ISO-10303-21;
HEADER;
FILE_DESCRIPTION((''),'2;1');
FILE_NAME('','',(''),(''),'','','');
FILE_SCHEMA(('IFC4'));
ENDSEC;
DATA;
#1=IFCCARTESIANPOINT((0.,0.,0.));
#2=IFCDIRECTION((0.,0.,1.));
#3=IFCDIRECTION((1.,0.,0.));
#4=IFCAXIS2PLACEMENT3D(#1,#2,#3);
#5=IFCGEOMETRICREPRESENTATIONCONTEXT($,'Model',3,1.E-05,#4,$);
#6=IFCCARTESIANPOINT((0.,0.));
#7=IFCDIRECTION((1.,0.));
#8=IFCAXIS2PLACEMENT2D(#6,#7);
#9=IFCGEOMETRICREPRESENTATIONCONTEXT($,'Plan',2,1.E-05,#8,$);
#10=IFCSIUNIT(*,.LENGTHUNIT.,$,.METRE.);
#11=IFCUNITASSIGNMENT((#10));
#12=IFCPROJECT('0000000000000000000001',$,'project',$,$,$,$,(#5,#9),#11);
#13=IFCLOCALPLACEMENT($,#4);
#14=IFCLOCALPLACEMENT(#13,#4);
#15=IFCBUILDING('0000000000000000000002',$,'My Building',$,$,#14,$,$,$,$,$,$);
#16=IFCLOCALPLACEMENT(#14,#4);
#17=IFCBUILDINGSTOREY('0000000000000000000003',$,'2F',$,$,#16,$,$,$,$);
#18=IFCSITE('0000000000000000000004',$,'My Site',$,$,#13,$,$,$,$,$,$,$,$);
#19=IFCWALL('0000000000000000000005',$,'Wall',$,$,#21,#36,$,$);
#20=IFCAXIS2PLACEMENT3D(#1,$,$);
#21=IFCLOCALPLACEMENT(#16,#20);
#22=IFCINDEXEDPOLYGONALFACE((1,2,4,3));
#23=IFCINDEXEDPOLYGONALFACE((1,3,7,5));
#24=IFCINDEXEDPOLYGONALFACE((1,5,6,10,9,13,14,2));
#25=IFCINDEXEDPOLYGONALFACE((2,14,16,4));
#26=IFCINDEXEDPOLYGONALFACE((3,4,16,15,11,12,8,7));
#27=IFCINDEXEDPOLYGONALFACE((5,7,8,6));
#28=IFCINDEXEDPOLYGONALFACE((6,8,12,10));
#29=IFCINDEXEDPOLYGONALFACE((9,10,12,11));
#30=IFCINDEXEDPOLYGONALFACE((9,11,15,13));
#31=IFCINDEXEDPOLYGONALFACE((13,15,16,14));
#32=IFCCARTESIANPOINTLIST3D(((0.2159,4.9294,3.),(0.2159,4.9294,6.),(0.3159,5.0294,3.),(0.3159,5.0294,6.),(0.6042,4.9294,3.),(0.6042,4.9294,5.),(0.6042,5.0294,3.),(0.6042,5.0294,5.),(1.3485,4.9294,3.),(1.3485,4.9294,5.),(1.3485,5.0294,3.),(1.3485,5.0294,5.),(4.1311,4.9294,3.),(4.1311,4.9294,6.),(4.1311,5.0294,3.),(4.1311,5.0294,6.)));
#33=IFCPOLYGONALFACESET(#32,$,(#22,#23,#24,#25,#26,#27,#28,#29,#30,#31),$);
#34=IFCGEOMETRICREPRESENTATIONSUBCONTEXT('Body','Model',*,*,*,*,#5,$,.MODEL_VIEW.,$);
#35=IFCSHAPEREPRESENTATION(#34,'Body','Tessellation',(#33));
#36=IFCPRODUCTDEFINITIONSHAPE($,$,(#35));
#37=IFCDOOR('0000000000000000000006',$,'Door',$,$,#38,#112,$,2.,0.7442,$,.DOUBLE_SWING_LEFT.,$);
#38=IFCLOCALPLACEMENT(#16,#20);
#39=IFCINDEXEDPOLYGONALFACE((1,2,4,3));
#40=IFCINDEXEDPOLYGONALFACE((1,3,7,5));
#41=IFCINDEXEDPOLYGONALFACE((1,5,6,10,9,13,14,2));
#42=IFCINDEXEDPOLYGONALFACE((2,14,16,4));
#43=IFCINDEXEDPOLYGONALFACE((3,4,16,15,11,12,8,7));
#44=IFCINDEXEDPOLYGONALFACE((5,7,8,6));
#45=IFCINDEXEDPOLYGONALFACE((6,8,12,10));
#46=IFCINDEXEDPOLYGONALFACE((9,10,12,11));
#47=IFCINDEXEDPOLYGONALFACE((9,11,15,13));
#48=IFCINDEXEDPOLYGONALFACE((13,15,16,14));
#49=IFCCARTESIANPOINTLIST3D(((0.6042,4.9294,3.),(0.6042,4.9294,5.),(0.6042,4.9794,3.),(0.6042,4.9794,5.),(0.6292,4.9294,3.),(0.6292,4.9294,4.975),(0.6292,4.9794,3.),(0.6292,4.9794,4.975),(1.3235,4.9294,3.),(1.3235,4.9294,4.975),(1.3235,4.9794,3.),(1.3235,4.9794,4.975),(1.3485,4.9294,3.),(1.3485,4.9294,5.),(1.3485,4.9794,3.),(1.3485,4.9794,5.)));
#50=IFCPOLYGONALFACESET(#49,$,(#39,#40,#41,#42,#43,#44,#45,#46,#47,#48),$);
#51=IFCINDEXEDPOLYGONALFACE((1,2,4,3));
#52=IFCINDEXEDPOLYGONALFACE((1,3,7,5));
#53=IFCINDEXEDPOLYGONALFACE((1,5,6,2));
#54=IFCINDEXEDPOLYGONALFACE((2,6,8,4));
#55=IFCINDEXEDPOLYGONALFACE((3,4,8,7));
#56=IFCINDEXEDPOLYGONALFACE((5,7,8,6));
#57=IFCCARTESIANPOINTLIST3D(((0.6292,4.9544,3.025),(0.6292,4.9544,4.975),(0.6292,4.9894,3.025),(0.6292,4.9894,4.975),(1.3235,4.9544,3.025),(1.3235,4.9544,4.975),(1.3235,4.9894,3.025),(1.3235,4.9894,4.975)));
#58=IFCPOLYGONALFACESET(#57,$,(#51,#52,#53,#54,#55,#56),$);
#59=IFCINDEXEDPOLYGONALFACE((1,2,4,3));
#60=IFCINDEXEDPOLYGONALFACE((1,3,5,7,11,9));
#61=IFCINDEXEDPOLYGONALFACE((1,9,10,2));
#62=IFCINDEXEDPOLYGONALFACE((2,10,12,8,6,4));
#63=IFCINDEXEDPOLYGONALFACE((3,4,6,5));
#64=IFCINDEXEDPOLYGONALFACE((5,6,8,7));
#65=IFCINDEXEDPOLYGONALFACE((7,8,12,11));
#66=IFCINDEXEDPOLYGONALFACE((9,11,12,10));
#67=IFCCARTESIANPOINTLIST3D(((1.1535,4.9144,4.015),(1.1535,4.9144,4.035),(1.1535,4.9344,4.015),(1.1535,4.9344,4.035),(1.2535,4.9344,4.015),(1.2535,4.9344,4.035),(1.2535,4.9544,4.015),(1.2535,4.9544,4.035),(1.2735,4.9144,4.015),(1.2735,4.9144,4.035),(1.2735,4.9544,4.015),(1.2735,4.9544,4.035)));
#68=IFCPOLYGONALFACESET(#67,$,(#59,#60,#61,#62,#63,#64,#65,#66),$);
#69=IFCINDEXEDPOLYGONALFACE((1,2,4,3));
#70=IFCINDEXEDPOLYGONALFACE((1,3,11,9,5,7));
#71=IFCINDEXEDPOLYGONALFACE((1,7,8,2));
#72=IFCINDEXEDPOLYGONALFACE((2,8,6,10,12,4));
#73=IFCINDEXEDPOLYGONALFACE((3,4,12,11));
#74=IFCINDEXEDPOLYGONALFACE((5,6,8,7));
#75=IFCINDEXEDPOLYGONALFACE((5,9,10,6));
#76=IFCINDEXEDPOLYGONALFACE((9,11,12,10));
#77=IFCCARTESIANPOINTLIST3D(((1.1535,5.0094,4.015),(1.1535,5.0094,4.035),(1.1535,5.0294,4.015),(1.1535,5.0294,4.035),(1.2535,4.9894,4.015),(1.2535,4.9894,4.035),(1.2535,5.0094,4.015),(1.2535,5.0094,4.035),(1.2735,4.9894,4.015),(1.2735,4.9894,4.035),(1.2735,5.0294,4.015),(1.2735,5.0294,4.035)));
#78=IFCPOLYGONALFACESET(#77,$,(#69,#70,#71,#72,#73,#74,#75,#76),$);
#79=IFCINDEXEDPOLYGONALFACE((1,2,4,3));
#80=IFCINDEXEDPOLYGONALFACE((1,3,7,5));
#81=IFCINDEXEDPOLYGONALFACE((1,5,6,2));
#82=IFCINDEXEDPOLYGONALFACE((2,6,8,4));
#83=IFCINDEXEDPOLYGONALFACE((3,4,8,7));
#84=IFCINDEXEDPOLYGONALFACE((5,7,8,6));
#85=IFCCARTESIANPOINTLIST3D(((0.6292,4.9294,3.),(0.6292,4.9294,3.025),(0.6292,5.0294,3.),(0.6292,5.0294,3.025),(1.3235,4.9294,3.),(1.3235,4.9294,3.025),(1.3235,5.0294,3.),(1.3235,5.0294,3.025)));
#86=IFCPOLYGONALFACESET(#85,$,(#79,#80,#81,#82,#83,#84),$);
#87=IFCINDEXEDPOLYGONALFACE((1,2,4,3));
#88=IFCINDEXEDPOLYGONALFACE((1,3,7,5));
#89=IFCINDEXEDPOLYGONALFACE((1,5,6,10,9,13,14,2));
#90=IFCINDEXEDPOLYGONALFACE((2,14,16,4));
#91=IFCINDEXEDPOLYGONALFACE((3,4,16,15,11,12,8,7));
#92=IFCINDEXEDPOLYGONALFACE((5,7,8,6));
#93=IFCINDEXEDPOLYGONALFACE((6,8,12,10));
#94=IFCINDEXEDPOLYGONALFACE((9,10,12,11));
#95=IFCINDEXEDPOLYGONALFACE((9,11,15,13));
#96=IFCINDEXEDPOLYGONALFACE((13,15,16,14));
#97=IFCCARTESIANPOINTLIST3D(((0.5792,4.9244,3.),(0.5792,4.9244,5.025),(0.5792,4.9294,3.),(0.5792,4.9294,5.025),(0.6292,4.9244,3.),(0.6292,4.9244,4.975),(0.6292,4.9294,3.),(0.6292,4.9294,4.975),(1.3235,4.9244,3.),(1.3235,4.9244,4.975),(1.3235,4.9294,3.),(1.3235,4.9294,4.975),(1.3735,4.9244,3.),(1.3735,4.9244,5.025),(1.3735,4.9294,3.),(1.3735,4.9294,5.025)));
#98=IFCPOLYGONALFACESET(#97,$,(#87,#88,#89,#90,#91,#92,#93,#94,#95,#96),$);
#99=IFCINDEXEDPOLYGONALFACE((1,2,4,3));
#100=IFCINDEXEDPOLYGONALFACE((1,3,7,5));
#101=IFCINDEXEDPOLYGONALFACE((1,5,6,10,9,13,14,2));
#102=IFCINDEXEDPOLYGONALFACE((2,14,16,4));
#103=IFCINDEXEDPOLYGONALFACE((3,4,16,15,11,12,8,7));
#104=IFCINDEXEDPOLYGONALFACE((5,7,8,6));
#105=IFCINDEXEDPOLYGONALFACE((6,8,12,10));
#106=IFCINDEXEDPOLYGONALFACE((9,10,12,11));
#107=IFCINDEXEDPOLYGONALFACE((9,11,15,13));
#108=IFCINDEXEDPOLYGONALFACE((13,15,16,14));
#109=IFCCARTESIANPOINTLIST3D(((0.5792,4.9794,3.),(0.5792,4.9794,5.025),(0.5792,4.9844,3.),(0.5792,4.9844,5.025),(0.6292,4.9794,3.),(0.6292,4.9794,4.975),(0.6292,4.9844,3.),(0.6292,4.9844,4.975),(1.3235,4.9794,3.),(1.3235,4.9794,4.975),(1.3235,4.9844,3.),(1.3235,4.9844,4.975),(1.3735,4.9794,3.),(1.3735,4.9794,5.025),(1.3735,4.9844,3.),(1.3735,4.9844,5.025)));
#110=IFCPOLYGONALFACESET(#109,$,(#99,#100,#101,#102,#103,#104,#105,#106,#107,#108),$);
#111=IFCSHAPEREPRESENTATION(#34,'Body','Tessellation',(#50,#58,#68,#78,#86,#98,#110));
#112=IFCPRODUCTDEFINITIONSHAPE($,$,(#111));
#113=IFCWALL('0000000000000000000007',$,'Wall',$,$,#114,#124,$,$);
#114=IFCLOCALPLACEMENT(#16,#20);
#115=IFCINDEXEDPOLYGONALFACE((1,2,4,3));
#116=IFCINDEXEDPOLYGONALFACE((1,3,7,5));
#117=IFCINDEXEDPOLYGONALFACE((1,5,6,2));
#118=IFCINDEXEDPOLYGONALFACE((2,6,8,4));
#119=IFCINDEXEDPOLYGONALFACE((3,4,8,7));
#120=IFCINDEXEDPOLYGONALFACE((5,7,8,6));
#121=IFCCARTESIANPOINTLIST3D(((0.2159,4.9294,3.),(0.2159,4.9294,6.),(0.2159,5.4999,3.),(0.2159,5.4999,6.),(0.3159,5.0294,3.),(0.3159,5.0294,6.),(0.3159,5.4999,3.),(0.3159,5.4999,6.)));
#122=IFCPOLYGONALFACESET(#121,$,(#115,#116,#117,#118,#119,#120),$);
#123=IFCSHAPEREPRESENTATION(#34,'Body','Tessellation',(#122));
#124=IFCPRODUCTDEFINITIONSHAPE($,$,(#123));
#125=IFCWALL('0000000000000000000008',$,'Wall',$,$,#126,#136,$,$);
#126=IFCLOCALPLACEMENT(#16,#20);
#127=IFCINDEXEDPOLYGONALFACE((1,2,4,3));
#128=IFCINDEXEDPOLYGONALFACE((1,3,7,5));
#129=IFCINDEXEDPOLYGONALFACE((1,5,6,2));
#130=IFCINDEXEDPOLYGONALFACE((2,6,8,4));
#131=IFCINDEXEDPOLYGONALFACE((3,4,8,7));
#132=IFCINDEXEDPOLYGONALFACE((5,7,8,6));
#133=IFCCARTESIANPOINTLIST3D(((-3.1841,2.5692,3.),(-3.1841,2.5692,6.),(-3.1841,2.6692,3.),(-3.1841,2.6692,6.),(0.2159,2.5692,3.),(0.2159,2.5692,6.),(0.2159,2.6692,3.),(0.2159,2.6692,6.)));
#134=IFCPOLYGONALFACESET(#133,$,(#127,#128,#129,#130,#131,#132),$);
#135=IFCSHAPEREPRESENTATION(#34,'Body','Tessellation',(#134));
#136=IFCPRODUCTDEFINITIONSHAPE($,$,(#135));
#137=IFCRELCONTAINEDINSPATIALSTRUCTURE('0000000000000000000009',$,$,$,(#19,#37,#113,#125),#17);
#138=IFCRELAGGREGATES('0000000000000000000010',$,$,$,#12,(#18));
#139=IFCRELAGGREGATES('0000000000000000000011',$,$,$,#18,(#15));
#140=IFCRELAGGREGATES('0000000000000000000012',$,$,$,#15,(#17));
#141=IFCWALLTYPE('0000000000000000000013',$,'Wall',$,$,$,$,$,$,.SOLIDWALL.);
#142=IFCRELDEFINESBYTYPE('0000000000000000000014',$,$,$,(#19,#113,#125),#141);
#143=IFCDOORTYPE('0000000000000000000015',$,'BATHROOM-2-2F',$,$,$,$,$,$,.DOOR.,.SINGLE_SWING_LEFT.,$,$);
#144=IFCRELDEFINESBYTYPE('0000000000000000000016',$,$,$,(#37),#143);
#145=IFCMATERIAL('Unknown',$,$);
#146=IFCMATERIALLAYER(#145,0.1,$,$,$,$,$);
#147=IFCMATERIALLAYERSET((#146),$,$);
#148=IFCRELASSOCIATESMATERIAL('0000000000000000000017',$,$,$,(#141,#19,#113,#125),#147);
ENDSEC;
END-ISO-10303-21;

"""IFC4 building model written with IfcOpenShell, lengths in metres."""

from ifc_helpers import new_model, entity, si_unit, frame, origin_with_axes, origin_2d_with_axis, place, context, subcontext, project, spatial, line, indexed_curve, outline, extrude, shape, source, transform, mapped, material, layer, layer_set, layer_usage, type_object, type_shapes, element, fill, save


model = new_model("IFC4")

# Units and contexts
model_context = context("Model", 3, precision=1e-05, world=origin_with_axes())
plan_context = context("Plan", 2, precision=1e-05, world=origin_2d_with_axis())
body_context_1 = subcontext(model_context, "Body", "Model", "MODEL_VIEW")
body_context_2 = subcontext(plan_context, "Body", "Plan", "PLAN_VIEW")
ifc_project = project(units=[si_unit("LENGTHUNIT", "METRE")], contexts=[model_context, plan_context])

# Site, building, storey
site_placement = place(None, origin_with_axes())
site = spatial("IfcSite", under=ifc_project, at=site_placement, Name="My Site")
building_placement = place(site_placement, origin_with_axes())
building = spatial("IfcBuilding", under=site, at=building_placement, Name="My Building")
storey_placement = place(building_placement, origin_with_axes())
storey = spatial("IfcBuildingStorey", under=building, at=storey_placement, Name="2F")

# Shared definitions
ifc_material = material(Name="Unknown")

# Shared definitions
ifc_layer_1 = layer(ifc_material, 0.1)
ifc_layer_set_1 = layer_set([ifc_layer_1])
wall_type = type_object("IfcWallType", Name="Wall", PredefinedType="SOLIDWALL", material=ifc_layer_set_1)

# Wall, opening, door
ifc_layer_usage_1 = layer_usage(ifc_layer_set_1, "AXIS2", "POSITIVE", 0.0)
wall_1_placement = place(storey_placement, frame((4.1311, 5.0294, 3.0), z_axis=(0.0, 0.0, 1.0), x_axis=(-1.0, 0.0, 0.0)))
wall_1 = element("IfcWall", 1, at=wall_1_placement, inside=storey, type_object=wall_type, material=ifc_layer_usage_1, Name="Wall", context=body_context_1, shape_type="SweptSolid", body=[
    extrude(outline(indexed_curve([(0.0, 0.0), (0.0, 0.1), (3.9153, 0.1), (3.8153, 0.0)], segments=[line(1, 2, 3, 4, 1)])), origin_with_axes(), (0.0, 0.0, 1.0), 3.0),
])
shared_shape_1 = source(origin_with_axes(), body_context_1, "Body", "SweptSolid", [
    extrude(outline(indexed_curve([(0.0, 0.0), (0.7442, 0.0), (0.7442, 2.0), (0.0, 2.0)], segments=[line(1, 2, 3, 4, 1)])), frame((0.0, -0.6, 0.0), z_axis=(0.0, -1.0, 0.0), x_axis=(1.0, 0.0, 0.0)), (0.0, 0.0, -1.0), 1.2),
])
opening_1_placement = place(wall_1_placement, frame((3.5269, 0.1, 0.0), z_axis=(0.0, 0.0, 1.0), x_axis=(-1.0, 0.0, 0.0)))
opening_1 = element("IfcOpeningElement", 2, at=opening_1_placement, cuts=wall_1, PredefinedType="OPENING", context=body_context_1, shape_type="MappedRepresentation", body=[
    mapped(shared_shape_1, transform((0.0, 0.0, 0.0), x_axis=(1.0, 0.0, 0.0), y_axis=(0.0, 1.0, 0.0), z_axis=(0.0, 0.0, 1.0), scale=1.0)),
])
door_type_1 = type_object("IfcDoorType", Name="BATHROOM-2-2F", OperationType="SINGLE_SWING_LEFT", PredefinedType="DOOR")
shared_shape_2 = source(origin_with_axes(), body_context_1, "Body", "SweptSolid", [
    extrude(outline(indexed_curve([(0.0, 0.0), (0.0, 2.0), (0.7442, 2.0), (0.7442, 0.0), (0.7192, 0.0), (0.7192, 1.975), (0.025, 1.975), (0.025, 0.0)], segments=[line(1, 2, 3, 4, 5, 6, 7, 8, 1)])), frame((0.0, 0.0, 0.0), z_axis=(0.0, -1.0, 0.0), x_axis=(1.0, 0.0, 0.0)), (0.0, 0.0, -1.0), 0.05),
    extrude(outline(indexed_curve([(0.0, 0.0), (0.6942, 0.0), (0.6942, 0.035), (0.0, 0.035)], segments=[line(1, 2, 3, 4, 1)])), frame((0.025, 0.025, 0.025), z_axis=(0.0, 0.0, 1.0), x_axis=(1.0, 0.0, 0.0)), (0.0, 0.0, 1.0), 1.95),
    extrude(outline(indexed_curve([(0.0, 0.0), (0.0, -0.04), (-0.12, -0.04), (-0.12, -0.02), (-0.02, -0.02), (-0.02, 0.0)], segments=[line(1, 2, 3, 4, 5, 6, 1)])), frame((0.6692, 0.025, 1.015), z_axis=(0.0, 0.0, 1.0), x_axis=(1.0, 0.0, 0.0)), (0.0, 0.0, 1.0), 0.02),
    extrude(outline(indexed_curve([(0.0, 0.0), (0.0, 0.04), (-0.12, 0.04), (-0.12, 0.02), (-0.02, 0.02), (-0.02, 0.0)], segments=[line(1, 2, 3, 4, 5, 6, 1)])), frame((0.6692, 0.06, 1.015), z_axis=(0.0, 0.0, 1.0), x_axis=(1.0, 0.0, 0.0)), (0.0, 0.0, 1.0), 0.02),
    extrude(outline(indexed_curve([(0.0, 0.0), (0.6942, 0.0), (0.6942, 0.1), (0.0, 0.1)], segments=[line(1, 2, 3, 4, 1)])), frame((0.025, 0.0, 0.0), z_axis=(0.0, 0.0, 1.0), x_axis=(1.0, 0.0, 0.0)), (0.0, 0.0, 1.0), 0.025),
    extrude(outline(indexed_curve([(0.0, 0.0), (0.0, 2.025), (0.7942, 2.025), (0.7942, 0.0), (0.7442, 0.0), (0.7442, 1.975), (0.05, 1.975), (0.05, 0.0)], segments=[line(1, 2, 3, 4, 5, 6, 7, 8, 1)])), frame((-0.025, -0.005, 0.0), z_axis=(0.0, -1.0, 0.0), x_axis=(1.0, 0.0, 0.0)), (0.0, 0.0, -1.0), 0.005),
    extrude(outline(indexed_curve([(0.0, 0.0), (0.0, 2.025), (0.7942, 2.025), (0.7942, 0.0), (0.7442, 0.0), (0.7442, 1.975), (0.05, 1.975), (0.05, 0.0)], segments=[line(1, 2, 3, 4, 5, 6, 7, 8, 1)])), frame((-0.025, 0.05, 0.0), z_axis=(0.0, -1.0, 0.0), x_axis=(1.0, 0.0, 0.0)), (0.0, 0.0, -1.0), 0.005),
])
shared_shape_3 = source(origin_with_axes(), body_context_2, "Body", "Curve2D", [
    entity("IfcIndexedPolyCurve", entity("IfcCartesianPointList2D", [[0.0, 0.0], [0.025, 0.0], [0.025, 0.05], [0.0, 0.05]]), [entity("IfcLineIndex", [1, 2, 3, 4, 1])]),
    entity("IfcIndexedPolyCurve", entity("IfcCartesianPointList2D", [[0.7442, 0.0], [0.7192, 0.0], [0.7192, 0.05], [0.7442, 0.05]]), [entity("IfcLineIndex", [1, 2, 3, 4, 1])]),
    entity("IfcIndexedPolyCurve", entity("IfcCartesianPointList2D", [[0.025, 0.05], [0.025, -0.6442], [0.06, -0.6442]])),
    entity("IfcTrimmedCurve", entity("IfcEllipse", entity("IfcAxis2Placement2D", entity("IfcCartesianPoint", [0.06, 0.05]), entity("IfcDirection", [1.0, 0.0])), 0.6592, 0.6942), [entity("IfcCartesianPoint", [0.06, -0.6442])], [entity("IfcCartesianPoint", [0.06, 0.7442])], True, "CARTESIAN"),
    entity("IfcIndexedPolyCurve", entity("IfcCartesianPointList2D", [[0.025, 0.05], [0.06, 0.05], [0.06, 0.7442], [0.025, 0.7442]]), [entity("IfcLineIndex", [1, 2, 3, 4, 1])]),
])
type_shapes(door_type_1, [shared_shape_2, shared_shape_3])
door_1_placement = place(opening_1_placement, frame((0.0, 0.0, 0.0), z_axis=(0.0, 0.0, 1.0), x_axis=(1.0, 0.0, 0.0)))
door_1 = element("IfcDoor", 3, at=door_1_placement, inside=storey, type_object=door_type_1, Name="Door", OperationType="DOUBLE_SWING_LEFT", OverallHeight=2.0, OverallWidth=0.7442, shapes=[
    shape(body_context_1, "Body", "MappedRepresentation", [mapped(shared_shape_2, transform((0.0, 0.0, 0.0), x_axis=(1.0, 0.0, 0.0), y_axis=(0.0, 1.0, 0.0), z_axis=(0.0, 0.0, 1.0), scale=1.0))]),
    shape(body_context_2, "Body", "MappedRepresentation", [mapped(shared_shape_3, transform((0.0, 0.0, 0.0), x_axis=(1.0, 0.0, 0.0), y_axis=(0.0, 1.0, 0.0), z_axis=(0.0, 0.0, 1.0), scale=1.0))]),
])
fill(opening_1, door_1)

# Wall
ifc_layer_usage_2 = layer_usage(ifc_layer_set_1, "AXIS2", "POSITIVE", 0.0)
wall_2_placement = place(storey_placement, frame((0.3159, 5.0294, 3.0), z_axis=(0.0, 0.0, 1.0), x_axis=(0.0, 1.0, 0.0)))
element("IfcWall", 4, at=wall_2_placement, inside=storey, type_object=wall_type, material=ifc_layer_usage_2, Name="Wall", context=body_context_1, shape_type="SweptSolid", body=[
    extrude(outline(indexed_curve([(0.0, 0.0), (-0.1, 0.1), (0.4705, 0.1), (0.4705, 0.0)], segments=[line(1, 2, 3, 4, 1)])), origin_with_axes(), (0.0, 0.0, 1.0), 3.0),
])

# Wall
ifc_layer_usage_3 = layer_usage(ifc_layer_set_1, "AXIS2", "POSITIVE", 0.0)
wall_3_placement = place(storey_placement, frame((-3.1841, 2.5692, 3.0), z_axis=(0.0, 0.0, 1.0), x_axis=(1.0, 0.0, 0.0)))
element("IfcWall", 5, at=wall_3_placement, inside=storey, type_object=wall_type, material=ifc_layer_usage_3, Name="Wall", context=body_context_1, shape_type="SweptSolid", body=[
    extrude(outline(indexed_curve([(0.0, 0.0), (0.0, 0.1), (3.4, 0.1), (3.4, 0.0)], segments=[line(1, 2, 3, 4, 1)])), origin_with_axes(), (0.0, 0.0, 1.0), 3.0),
])

save(model, "model.ifc")
